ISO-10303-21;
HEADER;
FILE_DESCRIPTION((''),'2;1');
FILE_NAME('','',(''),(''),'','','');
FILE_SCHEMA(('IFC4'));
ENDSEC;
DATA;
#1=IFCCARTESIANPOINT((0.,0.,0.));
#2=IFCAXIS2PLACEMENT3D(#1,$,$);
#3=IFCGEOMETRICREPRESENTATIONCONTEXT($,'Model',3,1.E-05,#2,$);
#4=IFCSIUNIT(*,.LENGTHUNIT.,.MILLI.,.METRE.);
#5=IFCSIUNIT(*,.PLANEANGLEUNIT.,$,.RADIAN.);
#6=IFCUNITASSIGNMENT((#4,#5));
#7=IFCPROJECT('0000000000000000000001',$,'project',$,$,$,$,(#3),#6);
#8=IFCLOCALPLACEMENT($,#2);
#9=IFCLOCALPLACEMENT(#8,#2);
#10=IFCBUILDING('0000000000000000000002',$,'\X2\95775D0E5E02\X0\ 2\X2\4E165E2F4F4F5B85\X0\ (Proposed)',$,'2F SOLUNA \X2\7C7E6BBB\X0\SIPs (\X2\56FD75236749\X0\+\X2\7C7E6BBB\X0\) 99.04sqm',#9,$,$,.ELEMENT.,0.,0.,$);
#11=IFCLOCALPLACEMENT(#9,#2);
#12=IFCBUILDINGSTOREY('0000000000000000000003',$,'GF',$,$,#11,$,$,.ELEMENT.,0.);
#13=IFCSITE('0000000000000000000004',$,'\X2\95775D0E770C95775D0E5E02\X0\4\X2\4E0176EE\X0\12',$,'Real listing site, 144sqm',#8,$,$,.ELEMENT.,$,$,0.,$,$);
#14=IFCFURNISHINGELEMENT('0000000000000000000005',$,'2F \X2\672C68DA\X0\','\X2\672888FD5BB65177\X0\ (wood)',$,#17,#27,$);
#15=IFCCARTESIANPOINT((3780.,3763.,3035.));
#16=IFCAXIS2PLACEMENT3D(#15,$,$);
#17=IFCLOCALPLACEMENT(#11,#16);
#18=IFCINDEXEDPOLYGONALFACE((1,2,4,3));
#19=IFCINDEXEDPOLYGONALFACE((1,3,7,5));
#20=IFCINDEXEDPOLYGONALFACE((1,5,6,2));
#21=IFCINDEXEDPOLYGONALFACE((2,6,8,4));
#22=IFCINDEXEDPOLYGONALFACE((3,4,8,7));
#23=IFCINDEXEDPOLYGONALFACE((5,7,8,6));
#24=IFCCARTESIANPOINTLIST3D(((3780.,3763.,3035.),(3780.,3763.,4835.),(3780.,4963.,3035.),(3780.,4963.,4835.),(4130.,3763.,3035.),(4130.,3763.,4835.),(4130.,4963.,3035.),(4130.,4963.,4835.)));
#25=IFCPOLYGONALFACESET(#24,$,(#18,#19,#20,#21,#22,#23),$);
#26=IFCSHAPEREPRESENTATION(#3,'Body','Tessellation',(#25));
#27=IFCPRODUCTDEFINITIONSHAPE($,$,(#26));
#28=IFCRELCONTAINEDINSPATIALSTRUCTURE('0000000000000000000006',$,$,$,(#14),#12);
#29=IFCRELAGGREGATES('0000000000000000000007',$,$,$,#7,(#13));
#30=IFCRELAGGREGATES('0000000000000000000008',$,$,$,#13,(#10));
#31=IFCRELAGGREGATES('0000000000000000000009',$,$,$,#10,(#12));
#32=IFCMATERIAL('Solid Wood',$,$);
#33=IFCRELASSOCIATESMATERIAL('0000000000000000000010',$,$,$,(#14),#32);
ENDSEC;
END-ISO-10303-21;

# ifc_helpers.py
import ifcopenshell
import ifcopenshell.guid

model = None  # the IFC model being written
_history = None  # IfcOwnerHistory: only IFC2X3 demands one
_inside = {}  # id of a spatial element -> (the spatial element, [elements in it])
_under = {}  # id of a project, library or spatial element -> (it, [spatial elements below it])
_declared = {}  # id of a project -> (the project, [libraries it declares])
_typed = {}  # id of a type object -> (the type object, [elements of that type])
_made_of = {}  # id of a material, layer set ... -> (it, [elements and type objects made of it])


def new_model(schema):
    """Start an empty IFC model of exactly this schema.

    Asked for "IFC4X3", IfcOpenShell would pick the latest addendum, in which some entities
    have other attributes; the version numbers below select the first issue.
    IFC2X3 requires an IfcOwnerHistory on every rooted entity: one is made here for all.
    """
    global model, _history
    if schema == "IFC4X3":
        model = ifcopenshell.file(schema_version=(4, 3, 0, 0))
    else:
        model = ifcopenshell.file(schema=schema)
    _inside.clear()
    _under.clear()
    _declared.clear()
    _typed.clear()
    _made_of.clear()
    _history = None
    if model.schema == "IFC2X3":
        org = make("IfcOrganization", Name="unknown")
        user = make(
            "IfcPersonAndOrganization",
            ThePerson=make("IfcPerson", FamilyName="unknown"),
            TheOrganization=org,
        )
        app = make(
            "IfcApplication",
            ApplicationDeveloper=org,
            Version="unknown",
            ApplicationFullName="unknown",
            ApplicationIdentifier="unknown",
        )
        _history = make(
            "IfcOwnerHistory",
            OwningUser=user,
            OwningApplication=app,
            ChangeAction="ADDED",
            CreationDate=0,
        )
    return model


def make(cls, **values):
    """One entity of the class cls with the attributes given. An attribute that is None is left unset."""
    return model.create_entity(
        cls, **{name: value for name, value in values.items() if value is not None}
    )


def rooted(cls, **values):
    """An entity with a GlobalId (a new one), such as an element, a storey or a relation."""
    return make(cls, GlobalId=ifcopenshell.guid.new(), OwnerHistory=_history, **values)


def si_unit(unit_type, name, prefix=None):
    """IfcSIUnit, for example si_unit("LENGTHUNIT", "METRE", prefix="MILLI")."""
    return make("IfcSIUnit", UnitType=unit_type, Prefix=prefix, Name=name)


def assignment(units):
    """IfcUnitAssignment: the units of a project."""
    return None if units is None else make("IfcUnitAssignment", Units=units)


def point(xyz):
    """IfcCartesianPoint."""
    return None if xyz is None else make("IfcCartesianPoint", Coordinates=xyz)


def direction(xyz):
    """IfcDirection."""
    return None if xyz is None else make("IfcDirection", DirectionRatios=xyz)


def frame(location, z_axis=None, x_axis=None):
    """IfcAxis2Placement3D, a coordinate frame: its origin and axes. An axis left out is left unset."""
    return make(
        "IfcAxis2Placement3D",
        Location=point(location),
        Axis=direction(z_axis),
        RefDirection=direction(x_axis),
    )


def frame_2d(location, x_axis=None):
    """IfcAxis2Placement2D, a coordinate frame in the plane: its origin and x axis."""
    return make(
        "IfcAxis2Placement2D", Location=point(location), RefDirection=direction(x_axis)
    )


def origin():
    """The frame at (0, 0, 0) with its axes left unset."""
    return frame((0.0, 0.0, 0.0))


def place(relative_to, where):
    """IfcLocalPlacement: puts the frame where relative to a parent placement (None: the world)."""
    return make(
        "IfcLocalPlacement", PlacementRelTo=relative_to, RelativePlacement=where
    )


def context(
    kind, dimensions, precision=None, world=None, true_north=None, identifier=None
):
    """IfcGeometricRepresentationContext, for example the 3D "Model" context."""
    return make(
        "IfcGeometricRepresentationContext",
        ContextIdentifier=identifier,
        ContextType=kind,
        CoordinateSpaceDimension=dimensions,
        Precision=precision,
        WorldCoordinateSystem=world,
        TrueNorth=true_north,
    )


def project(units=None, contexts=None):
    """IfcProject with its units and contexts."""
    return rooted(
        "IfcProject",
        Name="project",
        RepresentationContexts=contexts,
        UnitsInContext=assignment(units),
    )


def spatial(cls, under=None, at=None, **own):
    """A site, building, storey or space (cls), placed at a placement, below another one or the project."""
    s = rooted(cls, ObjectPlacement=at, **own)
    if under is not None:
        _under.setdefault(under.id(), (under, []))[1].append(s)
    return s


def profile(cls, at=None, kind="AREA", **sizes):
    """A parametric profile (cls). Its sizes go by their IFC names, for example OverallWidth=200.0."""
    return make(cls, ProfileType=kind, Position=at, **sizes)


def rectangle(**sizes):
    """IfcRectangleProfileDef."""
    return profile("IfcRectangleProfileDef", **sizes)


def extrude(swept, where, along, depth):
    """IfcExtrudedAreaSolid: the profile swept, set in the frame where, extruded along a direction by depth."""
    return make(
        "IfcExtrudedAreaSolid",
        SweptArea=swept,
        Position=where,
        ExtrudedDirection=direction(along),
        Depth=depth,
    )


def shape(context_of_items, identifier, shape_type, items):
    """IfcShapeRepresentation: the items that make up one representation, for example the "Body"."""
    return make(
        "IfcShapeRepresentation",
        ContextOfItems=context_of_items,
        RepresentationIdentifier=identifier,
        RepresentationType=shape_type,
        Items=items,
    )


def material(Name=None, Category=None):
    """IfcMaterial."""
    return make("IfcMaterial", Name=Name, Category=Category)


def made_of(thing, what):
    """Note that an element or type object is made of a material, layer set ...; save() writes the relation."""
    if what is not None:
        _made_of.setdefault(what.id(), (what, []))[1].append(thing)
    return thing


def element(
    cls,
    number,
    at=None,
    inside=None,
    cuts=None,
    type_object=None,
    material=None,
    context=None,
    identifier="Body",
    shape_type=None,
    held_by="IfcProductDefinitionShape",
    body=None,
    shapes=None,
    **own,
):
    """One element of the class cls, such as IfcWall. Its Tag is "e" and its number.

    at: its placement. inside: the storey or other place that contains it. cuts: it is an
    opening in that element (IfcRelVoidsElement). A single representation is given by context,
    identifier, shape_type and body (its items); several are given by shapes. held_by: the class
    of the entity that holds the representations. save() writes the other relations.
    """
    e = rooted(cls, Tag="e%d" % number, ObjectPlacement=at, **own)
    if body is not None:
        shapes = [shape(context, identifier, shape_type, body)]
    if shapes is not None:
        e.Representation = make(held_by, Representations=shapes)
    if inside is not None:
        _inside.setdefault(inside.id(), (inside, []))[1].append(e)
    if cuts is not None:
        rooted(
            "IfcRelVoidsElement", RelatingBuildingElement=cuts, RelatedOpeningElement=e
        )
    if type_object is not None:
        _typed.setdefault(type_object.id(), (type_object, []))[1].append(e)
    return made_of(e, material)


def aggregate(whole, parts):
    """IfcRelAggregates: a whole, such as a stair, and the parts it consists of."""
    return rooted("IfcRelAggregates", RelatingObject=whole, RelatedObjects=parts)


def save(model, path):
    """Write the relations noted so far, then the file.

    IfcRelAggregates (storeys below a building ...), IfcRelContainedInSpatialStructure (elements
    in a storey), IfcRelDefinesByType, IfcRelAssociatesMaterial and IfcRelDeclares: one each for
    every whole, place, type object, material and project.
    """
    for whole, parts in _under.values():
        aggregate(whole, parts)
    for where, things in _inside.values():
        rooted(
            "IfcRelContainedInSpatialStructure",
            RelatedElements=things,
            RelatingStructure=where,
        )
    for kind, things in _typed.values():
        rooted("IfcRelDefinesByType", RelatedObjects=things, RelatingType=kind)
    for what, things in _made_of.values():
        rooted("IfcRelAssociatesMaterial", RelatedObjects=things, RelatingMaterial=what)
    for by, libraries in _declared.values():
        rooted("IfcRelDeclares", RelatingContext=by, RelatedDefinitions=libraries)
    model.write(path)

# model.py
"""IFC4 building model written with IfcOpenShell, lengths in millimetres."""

from ifc_helpers import new_model, si_unit, frame, frame_2d, origin, place, context, project, spatial, rectangle, extrude, material, element, save


model = new_model("IFC4")

# Units and contexts
model_context = context("Model", 3, precision=1e-05, world=origin())
ifc_project = project(units=[si_unit("LENGTHUNIT", "METRE", prefix="MILLI"), si_unit("PLANEANGLEUNIT", "RADIAN")], contexts=[model_context])

# Site, building, storey
site_placement = place(None, origin())
site = spatial("IfcSite", under=ifc_project, at=site_placement, Name="長崎県長崎市4丁目12", ObjectType="Real listing site, 144sqm", CompositionType="ELEMENT", RefElevation=0.0)
building_placement = place(site_placement, origin())
building = spatial("IfcBuilding", under=site, at=building_placement, Name="長崎市 2世帯住宅 (Proposed)", ObjectType="2F SOLUNA 籾殻SIPs (国産杉+籾殻) 99.04sqm", CompositionType="ELEMENT", ElevationOfRefHeight=0.0, ElevationOfTerrain=0.0)
storey_placement = place(building_placement, origin())
storey = spatial("IfcBuildingStorey", under=building, at=storey_placement, Name="GF", CompositionType="ELEMENT", Elevation=0.0)

# Shared definitions
ifc_material_1 = material(Name="Solid Wood")

# Furnishing element
furnishing_placement = place(storey_placement, frame((3780.0, 3763.0, 3035.0)))
element("IfcFurnishingElement", 1, at=furnishing_placement, inside=storey, material=ifc_material_1, Name="2F 本棚", Description="木製家具 (wood)", context=model_context, shape_type="SweptSolid", body=[
    extrude(rectangle(XDim=350.0, YDim=1200.0, at=frame_2d((175.0, 600.0))), frame((3780.0, 3763.0, 3035.0)), (0.0, 0.0, 1.0), 1800.0),
])

save(model, "model.ifc")
